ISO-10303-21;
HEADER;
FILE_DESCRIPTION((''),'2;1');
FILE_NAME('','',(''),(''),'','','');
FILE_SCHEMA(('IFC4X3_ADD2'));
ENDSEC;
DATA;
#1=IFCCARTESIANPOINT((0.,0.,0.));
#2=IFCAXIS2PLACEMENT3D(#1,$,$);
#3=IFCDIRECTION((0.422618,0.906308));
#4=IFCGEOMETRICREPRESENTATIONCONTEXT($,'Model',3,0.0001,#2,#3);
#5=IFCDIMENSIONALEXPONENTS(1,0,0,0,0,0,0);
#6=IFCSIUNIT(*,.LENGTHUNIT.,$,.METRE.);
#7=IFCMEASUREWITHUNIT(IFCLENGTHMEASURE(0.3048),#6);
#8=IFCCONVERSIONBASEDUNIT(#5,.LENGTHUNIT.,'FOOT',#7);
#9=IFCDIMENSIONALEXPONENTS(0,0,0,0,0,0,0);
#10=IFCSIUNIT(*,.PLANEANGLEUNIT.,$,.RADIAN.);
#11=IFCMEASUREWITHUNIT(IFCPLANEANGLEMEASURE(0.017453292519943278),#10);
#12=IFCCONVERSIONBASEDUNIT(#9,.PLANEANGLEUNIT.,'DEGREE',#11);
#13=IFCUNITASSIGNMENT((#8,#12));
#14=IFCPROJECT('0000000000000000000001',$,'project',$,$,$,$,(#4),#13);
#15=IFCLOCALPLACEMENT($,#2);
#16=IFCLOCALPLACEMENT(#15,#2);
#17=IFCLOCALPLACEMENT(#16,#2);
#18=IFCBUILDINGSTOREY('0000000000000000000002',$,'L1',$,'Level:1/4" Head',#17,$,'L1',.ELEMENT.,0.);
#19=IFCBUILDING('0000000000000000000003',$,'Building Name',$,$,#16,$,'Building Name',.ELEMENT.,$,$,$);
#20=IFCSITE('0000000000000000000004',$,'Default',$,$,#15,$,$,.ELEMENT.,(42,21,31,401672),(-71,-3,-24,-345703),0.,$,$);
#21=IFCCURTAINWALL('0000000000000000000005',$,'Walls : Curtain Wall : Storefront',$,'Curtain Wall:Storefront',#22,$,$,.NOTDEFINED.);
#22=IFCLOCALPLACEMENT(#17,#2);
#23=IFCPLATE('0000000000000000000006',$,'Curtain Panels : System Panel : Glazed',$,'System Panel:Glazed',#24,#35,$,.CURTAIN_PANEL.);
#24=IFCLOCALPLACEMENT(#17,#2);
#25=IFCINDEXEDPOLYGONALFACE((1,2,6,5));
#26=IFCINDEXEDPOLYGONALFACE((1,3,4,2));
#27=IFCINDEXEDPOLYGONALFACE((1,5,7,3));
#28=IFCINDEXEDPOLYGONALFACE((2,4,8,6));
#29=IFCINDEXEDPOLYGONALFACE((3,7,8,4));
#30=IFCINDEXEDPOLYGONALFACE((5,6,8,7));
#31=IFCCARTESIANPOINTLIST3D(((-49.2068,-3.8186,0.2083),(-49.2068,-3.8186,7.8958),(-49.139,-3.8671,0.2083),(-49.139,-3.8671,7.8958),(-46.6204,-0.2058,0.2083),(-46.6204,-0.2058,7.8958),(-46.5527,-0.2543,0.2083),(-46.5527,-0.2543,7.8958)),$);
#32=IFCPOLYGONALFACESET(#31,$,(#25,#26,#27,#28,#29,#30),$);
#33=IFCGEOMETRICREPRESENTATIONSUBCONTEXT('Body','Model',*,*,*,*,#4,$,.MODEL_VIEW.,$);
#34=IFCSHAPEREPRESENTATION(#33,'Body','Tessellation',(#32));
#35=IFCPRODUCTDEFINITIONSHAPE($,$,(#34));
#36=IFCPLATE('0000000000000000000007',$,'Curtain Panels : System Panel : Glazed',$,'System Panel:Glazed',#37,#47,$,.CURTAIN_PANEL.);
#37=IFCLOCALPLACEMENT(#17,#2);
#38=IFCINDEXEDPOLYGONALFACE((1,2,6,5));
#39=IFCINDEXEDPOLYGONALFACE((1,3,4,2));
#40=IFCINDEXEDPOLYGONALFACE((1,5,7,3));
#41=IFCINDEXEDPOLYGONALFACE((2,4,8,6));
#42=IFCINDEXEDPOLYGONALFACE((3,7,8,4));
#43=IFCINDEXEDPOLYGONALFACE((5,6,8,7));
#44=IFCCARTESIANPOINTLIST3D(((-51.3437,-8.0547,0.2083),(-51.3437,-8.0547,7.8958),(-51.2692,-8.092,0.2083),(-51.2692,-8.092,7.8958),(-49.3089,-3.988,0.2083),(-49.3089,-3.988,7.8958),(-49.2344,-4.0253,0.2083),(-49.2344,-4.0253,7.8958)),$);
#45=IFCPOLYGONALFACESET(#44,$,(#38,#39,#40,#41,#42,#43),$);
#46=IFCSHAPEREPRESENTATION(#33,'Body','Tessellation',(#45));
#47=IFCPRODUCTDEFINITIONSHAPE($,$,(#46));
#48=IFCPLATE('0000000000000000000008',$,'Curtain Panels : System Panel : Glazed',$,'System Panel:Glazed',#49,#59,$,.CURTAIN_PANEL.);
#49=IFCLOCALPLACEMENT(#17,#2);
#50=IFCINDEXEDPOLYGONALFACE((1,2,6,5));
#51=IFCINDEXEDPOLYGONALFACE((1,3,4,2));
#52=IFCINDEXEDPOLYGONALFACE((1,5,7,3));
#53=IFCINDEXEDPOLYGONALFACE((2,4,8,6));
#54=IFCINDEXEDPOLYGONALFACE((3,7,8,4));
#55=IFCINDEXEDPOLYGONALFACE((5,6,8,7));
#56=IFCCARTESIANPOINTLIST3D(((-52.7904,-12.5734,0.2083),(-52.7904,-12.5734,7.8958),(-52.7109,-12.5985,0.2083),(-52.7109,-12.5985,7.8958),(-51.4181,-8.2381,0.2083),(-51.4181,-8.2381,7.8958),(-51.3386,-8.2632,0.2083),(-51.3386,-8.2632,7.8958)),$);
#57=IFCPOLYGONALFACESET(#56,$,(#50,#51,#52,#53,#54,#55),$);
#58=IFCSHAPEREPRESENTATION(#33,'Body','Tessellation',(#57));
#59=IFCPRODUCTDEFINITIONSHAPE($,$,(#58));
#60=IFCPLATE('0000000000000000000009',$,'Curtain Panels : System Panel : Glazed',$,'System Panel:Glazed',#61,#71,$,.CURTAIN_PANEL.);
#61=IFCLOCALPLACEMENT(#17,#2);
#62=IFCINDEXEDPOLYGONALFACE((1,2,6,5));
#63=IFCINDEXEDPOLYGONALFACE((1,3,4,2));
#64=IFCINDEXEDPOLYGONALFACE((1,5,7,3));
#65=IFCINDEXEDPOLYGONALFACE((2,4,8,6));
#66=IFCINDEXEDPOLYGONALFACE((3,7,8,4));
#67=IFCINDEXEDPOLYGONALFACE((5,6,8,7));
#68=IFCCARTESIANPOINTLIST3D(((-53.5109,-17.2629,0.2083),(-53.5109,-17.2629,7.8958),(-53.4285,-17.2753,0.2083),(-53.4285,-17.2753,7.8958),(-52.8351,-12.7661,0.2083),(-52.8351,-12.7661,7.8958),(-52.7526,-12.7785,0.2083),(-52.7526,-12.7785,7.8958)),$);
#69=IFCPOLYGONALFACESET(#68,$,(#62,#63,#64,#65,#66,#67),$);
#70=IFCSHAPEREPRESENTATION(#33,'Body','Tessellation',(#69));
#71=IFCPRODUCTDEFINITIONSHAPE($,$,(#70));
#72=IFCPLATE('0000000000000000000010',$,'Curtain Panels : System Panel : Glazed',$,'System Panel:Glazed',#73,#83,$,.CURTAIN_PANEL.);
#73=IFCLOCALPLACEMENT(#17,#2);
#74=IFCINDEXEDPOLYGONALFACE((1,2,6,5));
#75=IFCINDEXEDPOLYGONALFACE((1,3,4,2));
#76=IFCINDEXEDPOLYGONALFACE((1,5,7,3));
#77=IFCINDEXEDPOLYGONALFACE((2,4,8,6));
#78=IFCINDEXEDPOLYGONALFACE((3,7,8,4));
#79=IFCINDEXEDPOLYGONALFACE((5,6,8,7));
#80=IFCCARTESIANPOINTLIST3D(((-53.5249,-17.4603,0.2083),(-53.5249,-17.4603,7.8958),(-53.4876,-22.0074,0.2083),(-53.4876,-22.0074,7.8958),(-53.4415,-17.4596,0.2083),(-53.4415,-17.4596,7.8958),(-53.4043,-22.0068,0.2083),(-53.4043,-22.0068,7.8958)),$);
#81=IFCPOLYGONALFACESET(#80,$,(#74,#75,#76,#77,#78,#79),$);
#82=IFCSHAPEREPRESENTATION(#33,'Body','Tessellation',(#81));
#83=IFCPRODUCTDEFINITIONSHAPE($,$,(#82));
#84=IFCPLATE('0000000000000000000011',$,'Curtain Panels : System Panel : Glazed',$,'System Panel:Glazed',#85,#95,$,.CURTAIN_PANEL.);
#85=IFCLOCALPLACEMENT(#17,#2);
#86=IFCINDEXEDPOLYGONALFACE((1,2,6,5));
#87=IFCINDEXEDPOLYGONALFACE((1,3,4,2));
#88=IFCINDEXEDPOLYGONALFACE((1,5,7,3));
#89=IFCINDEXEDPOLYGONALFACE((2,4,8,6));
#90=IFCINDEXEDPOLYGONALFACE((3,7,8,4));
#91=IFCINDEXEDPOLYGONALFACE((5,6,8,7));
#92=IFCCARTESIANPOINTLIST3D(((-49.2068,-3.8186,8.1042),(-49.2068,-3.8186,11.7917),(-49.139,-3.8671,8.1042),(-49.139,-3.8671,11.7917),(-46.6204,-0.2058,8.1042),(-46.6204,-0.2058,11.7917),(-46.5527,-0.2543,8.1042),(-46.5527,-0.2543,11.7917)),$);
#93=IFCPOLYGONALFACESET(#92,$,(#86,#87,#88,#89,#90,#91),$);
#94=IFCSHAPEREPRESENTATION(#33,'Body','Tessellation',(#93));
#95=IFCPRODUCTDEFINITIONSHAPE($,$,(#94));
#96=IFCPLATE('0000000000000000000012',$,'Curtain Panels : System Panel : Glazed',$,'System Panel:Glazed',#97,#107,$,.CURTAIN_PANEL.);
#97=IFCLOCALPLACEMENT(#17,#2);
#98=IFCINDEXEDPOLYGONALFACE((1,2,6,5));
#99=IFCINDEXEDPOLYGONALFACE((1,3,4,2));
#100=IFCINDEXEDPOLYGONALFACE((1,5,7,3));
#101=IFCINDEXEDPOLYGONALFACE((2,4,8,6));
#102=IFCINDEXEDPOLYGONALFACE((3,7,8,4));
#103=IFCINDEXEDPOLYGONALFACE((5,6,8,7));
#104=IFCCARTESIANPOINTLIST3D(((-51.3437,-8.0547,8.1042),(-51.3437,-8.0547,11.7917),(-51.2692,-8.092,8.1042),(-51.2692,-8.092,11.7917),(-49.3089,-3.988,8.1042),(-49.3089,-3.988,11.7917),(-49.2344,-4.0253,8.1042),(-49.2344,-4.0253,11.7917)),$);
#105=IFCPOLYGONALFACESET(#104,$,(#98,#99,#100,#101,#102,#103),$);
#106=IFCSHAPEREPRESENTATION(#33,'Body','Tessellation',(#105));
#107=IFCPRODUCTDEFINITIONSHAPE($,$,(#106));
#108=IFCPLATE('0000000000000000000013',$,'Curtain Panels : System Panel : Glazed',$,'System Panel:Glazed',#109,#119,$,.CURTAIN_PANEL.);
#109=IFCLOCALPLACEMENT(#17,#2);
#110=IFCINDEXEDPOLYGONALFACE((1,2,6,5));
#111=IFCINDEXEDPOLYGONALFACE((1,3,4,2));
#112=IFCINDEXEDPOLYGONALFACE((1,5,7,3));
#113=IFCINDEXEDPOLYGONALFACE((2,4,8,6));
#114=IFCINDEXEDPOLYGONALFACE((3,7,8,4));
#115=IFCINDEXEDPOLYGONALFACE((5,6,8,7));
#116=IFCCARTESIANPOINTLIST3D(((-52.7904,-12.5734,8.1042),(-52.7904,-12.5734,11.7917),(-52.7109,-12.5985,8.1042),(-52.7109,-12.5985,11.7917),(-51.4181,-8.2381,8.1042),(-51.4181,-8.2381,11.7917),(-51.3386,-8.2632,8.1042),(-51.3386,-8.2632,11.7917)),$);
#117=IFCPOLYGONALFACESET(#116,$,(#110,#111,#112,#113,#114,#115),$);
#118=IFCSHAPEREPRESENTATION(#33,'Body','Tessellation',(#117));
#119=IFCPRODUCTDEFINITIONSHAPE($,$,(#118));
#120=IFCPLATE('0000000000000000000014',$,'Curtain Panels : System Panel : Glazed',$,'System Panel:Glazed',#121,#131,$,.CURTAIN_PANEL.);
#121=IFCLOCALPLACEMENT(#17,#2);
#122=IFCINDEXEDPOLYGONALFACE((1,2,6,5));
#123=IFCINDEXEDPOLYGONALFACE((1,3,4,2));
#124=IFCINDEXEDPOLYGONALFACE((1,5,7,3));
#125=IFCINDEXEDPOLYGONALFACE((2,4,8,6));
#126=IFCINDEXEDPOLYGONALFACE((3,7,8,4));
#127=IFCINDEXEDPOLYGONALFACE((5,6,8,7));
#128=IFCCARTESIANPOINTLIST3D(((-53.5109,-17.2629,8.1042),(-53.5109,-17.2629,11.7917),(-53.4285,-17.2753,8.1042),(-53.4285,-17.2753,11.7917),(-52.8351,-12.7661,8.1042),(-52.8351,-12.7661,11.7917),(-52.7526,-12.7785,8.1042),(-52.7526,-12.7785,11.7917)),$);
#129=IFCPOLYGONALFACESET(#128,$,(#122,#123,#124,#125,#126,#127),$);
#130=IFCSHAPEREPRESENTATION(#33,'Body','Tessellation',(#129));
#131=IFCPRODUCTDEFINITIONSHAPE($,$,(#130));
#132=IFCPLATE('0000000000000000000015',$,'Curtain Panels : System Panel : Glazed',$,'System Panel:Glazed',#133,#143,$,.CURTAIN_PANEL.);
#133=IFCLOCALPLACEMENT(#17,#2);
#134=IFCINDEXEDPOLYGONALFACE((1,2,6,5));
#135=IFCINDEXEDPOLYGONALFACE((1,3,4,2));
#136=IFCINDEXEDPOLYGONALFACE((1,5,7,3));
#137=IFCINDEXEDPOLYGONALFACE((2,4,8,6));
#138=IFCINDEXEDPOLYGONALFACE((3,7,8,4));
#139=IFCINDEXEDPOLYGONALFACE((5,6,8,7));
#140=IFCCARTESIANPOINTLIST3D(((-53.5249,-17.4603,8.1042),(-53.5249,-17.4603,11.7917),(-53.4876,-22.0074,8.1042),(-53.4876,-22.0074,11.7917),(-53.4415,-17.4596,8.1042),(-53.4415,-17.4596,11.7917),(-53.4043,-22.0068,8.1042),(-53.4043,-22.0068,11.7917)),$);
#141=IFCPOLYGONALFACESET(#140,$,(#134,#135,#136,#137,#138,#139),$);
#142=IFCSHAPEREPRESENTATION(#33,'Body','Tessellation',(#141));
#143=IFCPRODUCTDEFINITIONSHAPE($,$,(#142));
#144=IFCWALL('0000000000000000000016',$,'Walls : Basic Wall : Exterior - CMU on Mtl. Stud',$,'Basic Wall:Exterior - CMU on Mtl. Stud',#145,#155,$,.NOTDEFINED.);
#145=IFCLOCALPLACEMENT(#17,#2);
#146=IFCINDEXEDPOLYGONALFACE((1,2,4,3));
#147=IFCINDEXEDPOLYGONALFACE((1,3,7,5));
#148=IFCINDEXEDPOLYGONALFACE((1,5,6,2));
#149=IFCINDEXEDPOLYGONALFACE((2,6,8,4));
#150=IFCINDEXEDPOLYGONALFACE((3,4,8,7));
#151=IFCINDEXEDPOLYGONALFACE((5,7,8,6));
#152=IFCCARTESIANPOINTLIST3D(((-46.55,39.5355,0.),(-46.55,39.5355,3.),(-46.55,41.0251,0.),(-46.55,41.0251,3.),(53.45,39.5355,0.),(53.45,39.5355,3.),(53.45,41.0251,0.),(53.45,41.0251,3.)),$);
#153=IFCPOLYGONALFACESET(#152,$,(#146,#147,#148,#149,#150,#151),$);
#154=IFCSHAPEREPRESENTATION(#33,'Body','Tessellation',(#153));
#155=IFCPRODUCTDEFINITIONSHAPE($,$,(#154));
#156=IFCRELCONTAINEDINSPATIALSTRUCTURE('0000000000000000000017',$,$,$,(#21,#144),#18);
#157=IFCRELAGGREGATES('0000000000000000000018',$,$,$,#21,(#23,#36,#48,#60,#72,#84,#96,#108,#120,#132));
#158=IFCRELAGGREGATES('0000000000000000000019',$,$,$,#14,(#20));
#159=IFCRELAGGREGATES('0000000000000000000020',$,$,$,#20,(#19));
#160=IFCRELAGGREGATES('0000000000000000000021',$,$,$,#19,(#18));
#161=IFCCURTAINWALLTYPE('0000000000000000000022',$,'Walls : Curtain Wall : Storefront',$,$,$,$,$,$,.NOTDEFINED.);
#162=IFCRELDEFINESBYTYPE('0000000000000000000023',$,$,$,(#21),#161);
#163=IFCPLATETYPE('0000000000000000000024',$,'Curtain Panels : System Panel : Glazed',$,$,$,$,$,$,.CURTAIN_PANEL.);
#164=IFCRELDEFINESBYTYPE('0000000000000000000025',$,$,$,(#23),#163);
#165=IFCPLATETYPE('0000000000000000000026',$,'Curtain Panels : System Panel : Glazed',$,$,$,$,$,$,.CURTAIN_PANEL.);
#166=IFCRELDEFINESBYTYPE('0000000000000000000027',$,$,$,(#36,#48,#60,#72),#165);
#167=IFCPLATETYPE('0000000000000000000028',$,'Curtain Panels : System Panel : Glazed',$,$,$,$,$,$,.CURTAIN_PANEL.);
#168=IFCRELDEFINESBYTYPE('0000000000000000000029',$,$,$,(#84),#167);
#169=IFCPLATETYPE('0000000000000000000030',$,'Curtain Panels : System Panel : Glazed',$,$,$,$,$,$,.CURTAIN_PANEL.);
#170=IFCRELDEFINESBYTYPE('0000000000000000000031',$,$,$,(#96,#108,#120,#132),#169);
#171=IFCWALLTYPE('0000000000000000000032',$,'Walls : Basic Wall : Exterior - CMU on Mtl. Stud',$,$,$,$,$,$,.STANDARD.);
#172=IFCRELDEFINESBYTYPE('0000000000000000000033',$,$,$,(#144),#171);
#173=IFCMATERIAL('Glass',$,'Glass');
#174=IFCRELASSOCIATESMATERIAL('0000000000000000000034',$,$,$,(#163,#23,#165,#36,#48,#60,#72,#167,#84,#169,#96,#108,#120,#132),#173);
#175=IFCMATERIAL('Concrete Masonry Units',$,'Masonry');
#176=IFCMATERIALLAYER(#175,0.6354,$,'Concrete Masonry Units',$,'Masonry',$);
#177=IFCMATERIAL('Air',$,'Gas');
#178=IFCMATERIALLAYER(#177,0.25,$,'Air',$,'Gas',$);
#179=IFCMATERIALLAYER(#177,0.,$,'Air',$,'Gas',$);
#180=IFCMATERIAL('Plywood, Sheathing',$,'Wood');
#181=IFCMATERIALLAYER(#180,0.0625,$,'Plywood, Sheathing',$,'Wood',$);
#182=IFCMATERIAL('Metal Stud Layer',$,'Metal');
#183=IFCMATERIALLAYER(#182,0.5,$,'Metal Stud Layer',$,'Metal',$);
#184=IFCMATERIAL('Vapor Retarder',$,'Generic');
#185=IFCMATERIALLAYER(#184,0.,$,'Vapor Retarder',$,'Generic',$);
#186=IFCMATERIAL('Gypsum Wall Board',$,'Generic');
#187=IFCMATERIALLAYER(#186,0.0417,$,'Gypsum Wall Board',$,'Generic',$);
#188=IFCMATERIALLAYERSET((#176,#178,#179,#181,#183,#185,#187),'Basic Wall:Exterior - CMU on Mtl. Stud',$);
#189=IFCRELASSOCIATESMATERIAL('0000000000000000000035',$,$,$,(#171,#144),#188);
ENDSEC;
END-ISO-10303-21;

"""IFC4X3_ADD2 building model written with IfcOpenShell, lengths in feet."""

from ifc_helpers import new_model, entity, si_unit, converted_unit, direction, frame, frame_2d, origin, place, context, subcontext, project, spatial, rectangle, extrude, source, transform, mapped, material, layer, layer_set, type_object, type_shapes, element, aggregate, save


model = new_model("IFC4X3_ADD2")

# Units and contexts
model_context = context("Model", 3, precision=0.0001, world=origin(), true_north=direction((0.422618, 0.906308)))
body_context = subcontext(model_context, "Body", "Model", "MODEL_VIEW")
ifc_project = project(units=[converted_unit("LENGTHUNIT", "FOOT", entity("IfcLengthMeasure", 0.3048), si_unit("LENGTHUNIT", "METRE"), dimensions=[1, 0, 0, 0, 0, 0, 0]), converted_unit("PLANEANGLEUNIT", "DEGREE", entity("IfcPlaneAngleMeasure", 0.017453292519943278), si_unit("PLANEANGLEUNIT", "RADIAN"), dimensions=[0, 0, 0, 0, 0, 0, 0])], contexts=[model_context])

# Site, building, storey
site_placement = place(None, origin())
site = spatial("IfcSite", under=ifc_project, at=site_placement, Name="Default", CompositionType="ELEMENT", RefLatitude=(42, 21, 31, 401672), RefLongitude=(-71, -3, -24, -345703), RefElevation=0.0)
building_placement = place(site_placement, origin())
building = spatial("IfcBuilding", under=site, at=building_placement, Name="Building Name", LongName="Building Name", CompositionType="ELEMENT")
storey_placement = place(building_placement, origin())
storey = spatial("IfcBuildingStorey", under=building, at=storey_placement, Name="L1", ObjectType="Level:1/4\" Head", LongName="L1", CompositionType="ELEMENT", Elevation=0.0)

# Curtain wall, plates
curtain_wall_type = type_object("IfcCurtainWallType", Name="Walls : Curtain Wall : Storefront", PredefinedType="NOTDEFINED")
curtain_wall_placement = place(storey_placement, origin())
curtain_wall = element("IfcCurtainWall", 1, at=curtain_wall_placement, inside=storey, type_object=curtain_wall_type, Name="Walls : Curtain Wall : Storefront", ObjectType="Curtain Wall:Storefront", PredefinedType="NOTDEFINED")
ifc_material_1 = material(Name="Glass", Category="Glass")
plate_type_1 = type_object("IfcPlateType", Name="Curtain Panels : System Panel : Glazed", PredefinedType="CURTAIN_PANEL", material=ifc_material_1)
shared_shape_1 = source(origin(), body_context, "Body", "SweptSolid", [
    extrude(rectangle(XDim=0.0833, YDim=4.4431, at=frame_2d((0.0, 0.0), x_axis=(1.0, 0.0))), frame((2.2216, 0.0417, 0.0), z_axis=(0.0, 0.0, 1.0), x_axis=(0.0, 1.0, 0.0)), (0.0, 0.0, 1.0), 7.6875),
])
type_shapes(plate_type_1, [shared_shape_1])
plate_1_placement = place(curtain_wall_placement, frame((-46.6204, -0.2058, 0.2083), z_axis=(0.0, 0.0, 1.0), x_axis=(-0.582096, -0.81312, 0.0)))
plate_1 = element("IfcPlate", 2, at=plate_1_placement, type_object=plate_type_1, material=ifc_material_1, Name="Curtain Panels : System Panel : Glazed", ObjectType="System Panel:Glazed", PredefinedType="CURTAIN_PANEL", context=body_context, shape_type="MappedRepresentation", body=[
    mapped(shared_shape_1, transform((0.0, 0.0, 0.0), scale=1.0)),
])
plate_type_2 = type_object("IfcPlateType", Name="Curtain Panels : System Panel : Glazed", PredefinedType="CURTAIN_PANEL", material=ifc_material_1)
shared_shape_2 = source(origin(), body_context, "Body", "SweptSolid", [
    extrude(rectangle(XDim=0.0833, YDim=4.5473, at=frame_2d((0.0, 0.0), x_axis=(1.0, 0.0))), frame((2.2737, 0.0417, 0.0), z_axis=(0.0, 0.0, 1.0), x_axis=(0.0, 1.0, 0.0)), (0.0, 0.0, 1.0), 7.6875),
])
type_shapes(plate_type_2, [shared_shape_2])
plate_2_placement = place(curtain_wall_placement, frame((-49.3089, -3.988, 0.2083), z_axis=(0.0, 0.0, 1.0), x_axis=(-0.447467, -0.8943, 0.0)))
plate_2 = element("IfcPlate", 3, at=plate_2_placement, type_object=plate_type_2, material=ifc_material_1, Name="Curtain Panels : System Panel : Glazed", ObjectType="System Panel:Glazed", PredefinedType="CURTAIN_PANEL", context=body_context, shape_type="MappedRepresentation", body=[
    mapped(shared_shape_2, transform((0.0, 0.0, 0.0), scale=1.0)),
])
plate_3_placement = place(curtain_wall_placement, frame((-51.4181, -8.2381, 0.2083), z_axis=(0.0, 0.0, 1.0), x_axis=(-0.301779, -0.953378, 0.0)))
plate_3 = element("IfcPlate", 4, at=plate_3_placement, type_object=plate_type_2, material=ifc_material_1, Name="Curtain Panels : System Panel : Glazed", ObjectType="System Panel:Glazed", PredefinedType="CURTAIN_PANEL", context=body_context, shape_type="MappedRepresentation", body=[
    mapped(shared_shape_2, transform((0.0, 0.0, 0.0), scale=1.0)),
])
plate_4_placement = place(curtain_wall_placement, frame((-52.8351, -12.7661, 0.2083), z_axis=(0.0, 0.0, 1.0), x_axis=(-0.148632, -0.988893, 0.0)))
plate_4 = element("IfcPlate", 5, at=plate_4_placement, type_object=plate_type_2, material=ifc_material_1, Name="Curtain Panels : System Panel : Glazed", ObjectType="System Panel:Glazed", PredefinedType="CURTAIN_PANEL", context=body_context, shape_type="MappedRepresentation", body=[
    mapped(shared_shape_2, transform((0.0, 0.0, 0.0), scale=1.0)),
])
plate_5_placement = place(curtain_wall_placement, frame((-53.5249, -17.4603, 0.2083), z_axis=(0.0, 0.0, 1.0), x_axis=(0.008188, -0.999966, 0.0)))
plate_5 = element("IfcPlate", 6, at=plate_5_placement, type_object=plate_type_2, material=ifc_material_1, Name="Curtain Panels : System Panel : Glazed", ObjectType="System Panel:Glazed", PredefinedType="CURTAIN_PANEL", context=body_context, shape_type="MappedRepresentation", body=[
    mapped(shared_shape_2, transform((0.0, 0.0, 0.0), scale=1.0)),
])
plate_type_3 = type_object("IfcPlateType", Name="Curtain Panels : System Panel : Glazed", PredefinedType="CURTAIN_PANEL", material=ifc_material_1)
shared_shape_3 = source(origin(), body_context, "Body", "SweptSolid", [
    extrude(rectangle(XDim=0.0833, YDim=4.4431, at=frame_2d((0.0, 0.0), x_axis=(1.0, 0.0))), frame((2.2216, 0.0417, 0.0), z_axis=(0.0, 0.0, 1.0), x_axis=(0.0, 1.0, 0.0)), (0.0, 0.0, 1.0), 3.6875),
])
type_shapes(plate_type_3, [shared_shape_3])
plate_6_placement = place(curtain_wall_placement, frame((-46.6204, -0.2058, 8.1042), z_axis=(0.0, 0.0, 1.0), x_axis=(-0.582096, -0.81312, 0.0)))
plate_6 = element("IfcPlate", 7, at=plate_6_placement, type_object=plate_type_3, material=ifc_material_1, Name="Curtain Panels : System Panel : Glazed", ObjectType="System Panel:Glazed", PredefinedType="CURTAIN_PANEL", context=body_context, shape_type="MappedRepresentation", body=[
    mapped(shared_shape_3, transform((0.0, 0.0, 0.0), scale=1.0)),
])
plate_type_4 = type_object("IfcPlateType", Name="Curtain Panels : System Panel : Glazed", PredefinedType="CURTAIN_PANEL", material=ifc_material_1)
shared_shape_4 = source(origin(), body_context, "Body", "SweptSolid", [
    extrude(rectangle(XDim=0.0833, YDim=4.5473, at=frame_2d((0.0, 0.0), x_axis=(1.0, 0.0))), frame((2.2737, 0.0417, 0.0), z_axis=(0.0, 0.0, 1.0), x_axis=(0.0, 1.0, 0.0)), (0.0, 0.0, 1.0), 3.6875),
])
type_shapes(plate_type_4, [shared_shape_4])
plate_7_placement = place(curtain_wall_placement, frame((-49.3089, -3.988, 8.1042), z_axis=(0.0, 0.0, 1.0), x_axis=(-0.447467, -0.8943, 0.0)))
plate_7 = element("IfcPlate", 8, at=plate_7_placement, type_object=plate_type_4, material=ifc_material_1, Name="Curtain Panels : System Panel : Glazed", ObjectType="System Panel:Glazed", PredefinedType="CURTAIN_PANEL", context=body_context, shape_type="MappedRepresentation", body=[
    mapped(shared_shape_4, transform((0.0, 0.0, 0.0), scale=1.0)),
])
plate_8_placement = place(curtain_wall_placement, frame((-51.4181, -8.2381, 8.1042), z_axis=(0.0, 0.0, 1.0), x_axis=(-0.301779, -0.953378, 0.0)))
plate_8 = element("IfcPlate", 9, at=plate_8_placement, type_object=plate_type_4, material=ifc_material_1, Name="Curtain Panels : System Panel : Glazed", ObjectType="System Panel:Glazed", PredefinedType="CURTAIN_PANEL", context=body_context, shape_type="MappedRepresentation", body=[
    mapped(shared_shape_4, transform((0.0, 0.0, 0.0), scale=1.0)),
])
plate_9_placement = place(curtain_wall_placement, frame((-52.8351, -12.7661, 8.1042), z_axis=(0.0, 0.0, 1.0), x_axis=(-0.148632, -0.988893, 0.0)))
plate_9 = element("IfcPlate", 10, at=plate_9_placement, type_object=plate_type_4, material=ifc_material_1, Name="Curtain Panels : System Panel : Glazed", ObjectType="System Panel:Glazed", PredefinedType="CURTAIN_PANEL", context=body_context, shape_type="MappedRepresentation", body=[
    mapped(shared_shape_4, transform((0.0, 0.0, 0.0), scale=1.0)),
])
plate_10_placement = place(curtain_wall_placement, frame((-53.5249, -17.4603, 8.1042), z_axis=(0.0, 0.0, 1.0), x_axis=(0.008188, -0.999966, 0.0)))
plate_10 = element("IfcPlate", 11, at=plate_10_placement, type_object=plate_type_4, material=ifc_material_1, Name="Curtain Panels : System Panel : Glazed", ObjectType="System Panel:Glazed", PredefinedType="CURTAIN_PANEL", context=body_context, shape_type="MappedRepresentation", body=[
    mapped(shared_shape_4, transform((0.0, 0.0, 0.0), scale=1.0)),
])
aggregate(curtain_wall, [plate_1, plate_2, plate_3, plate_4, plate_5, plate_6, plate_7, plate_8, plate_9, plate_10])

# Wall
ifc_material_2 = material(Name="Concrete Masonry Units", Category="Masonry")
ifc_layer_1 = layer(ifc_material_2, 0.6354, Name="Concrete Masonry Units", Category="Masonry")
ifc_material_3 = material(Name="Air", Category="Gas")
ifc_layer_2 = layer(ifc_material_3, 0.25, Name="Air", Category="Gas")
ifc_layer_3 = layer(ifc_material_3, 0.0, Name="Air", Category="Gas")
ifc_material_4 = material(Name="Plywood, Sheathing", Category="Wood")
ifc_layer_4 = layer(ifc_material_4, 0.0625, Name="Plywood, Sheathing", Category="Wood")
ifc_material_5 = material(Name="Metal Stud Layer", Category="Metal")
ifc_layer_5 = layer(ifc_material_5, 0.5, Name="Metal Stud Layer", Category="Metal")
ifc_material_6 = material(Name="Vapor Retarder", Category="Generic")
ifc_layer_6 = layer(ifc_material_6, 0.0, Name="Vapor Retarder", Category="Generic")
ifc_material_7 = material(Name="Gypsum Wall Board", Category="Generic")
ifc_layer_7 = layer(ifc_material_7, 0.0417, Name="Gypsum Wall Board", Category="Generic")
ifc_layer_set_1 = layer_set([ifc_layer_1, ifc_layer_2, ifc_layer_3, ifc_layer_4, ifc_layer_5, ifc_layer_6, ifc_layer_7], Name="Basic Wall:Exterior - CMU on Mtl. Stud")
wall_type_1 = type_object("IfcWallType", Name="Walls : Basic Wall : Exterior - CMU on Mtl. Stud", PredefinedType="STANDARD", material=ifc_layer_set_1)
wall_1_placement = place(storey_placement, frame((-46.55, 40.2803, 0.0)))
element("IfcWall", 12, at=wall_1_placement, inside=storey, type_object=wall_type_1, material=ifc_layer_set_1, Name="Walls : Basic Wall : Exterior - CMU on Mtl. Stud", ObjectType="Basic Wall:Exterior - CMU on Mtl. Stud", PredefinedType="NOTDEFINED", context=body_context, shape_type="SweptSolid", body=[
    extrude(rectangle(XDim=100.0, YDim=1.4896, at=frame_2d((50.0, 0.0), x_axis=(-1.0, 0.0))), origin(), (0.0, 0.0, 1.0), 3.0),
])

save(model, "model.ifc")
